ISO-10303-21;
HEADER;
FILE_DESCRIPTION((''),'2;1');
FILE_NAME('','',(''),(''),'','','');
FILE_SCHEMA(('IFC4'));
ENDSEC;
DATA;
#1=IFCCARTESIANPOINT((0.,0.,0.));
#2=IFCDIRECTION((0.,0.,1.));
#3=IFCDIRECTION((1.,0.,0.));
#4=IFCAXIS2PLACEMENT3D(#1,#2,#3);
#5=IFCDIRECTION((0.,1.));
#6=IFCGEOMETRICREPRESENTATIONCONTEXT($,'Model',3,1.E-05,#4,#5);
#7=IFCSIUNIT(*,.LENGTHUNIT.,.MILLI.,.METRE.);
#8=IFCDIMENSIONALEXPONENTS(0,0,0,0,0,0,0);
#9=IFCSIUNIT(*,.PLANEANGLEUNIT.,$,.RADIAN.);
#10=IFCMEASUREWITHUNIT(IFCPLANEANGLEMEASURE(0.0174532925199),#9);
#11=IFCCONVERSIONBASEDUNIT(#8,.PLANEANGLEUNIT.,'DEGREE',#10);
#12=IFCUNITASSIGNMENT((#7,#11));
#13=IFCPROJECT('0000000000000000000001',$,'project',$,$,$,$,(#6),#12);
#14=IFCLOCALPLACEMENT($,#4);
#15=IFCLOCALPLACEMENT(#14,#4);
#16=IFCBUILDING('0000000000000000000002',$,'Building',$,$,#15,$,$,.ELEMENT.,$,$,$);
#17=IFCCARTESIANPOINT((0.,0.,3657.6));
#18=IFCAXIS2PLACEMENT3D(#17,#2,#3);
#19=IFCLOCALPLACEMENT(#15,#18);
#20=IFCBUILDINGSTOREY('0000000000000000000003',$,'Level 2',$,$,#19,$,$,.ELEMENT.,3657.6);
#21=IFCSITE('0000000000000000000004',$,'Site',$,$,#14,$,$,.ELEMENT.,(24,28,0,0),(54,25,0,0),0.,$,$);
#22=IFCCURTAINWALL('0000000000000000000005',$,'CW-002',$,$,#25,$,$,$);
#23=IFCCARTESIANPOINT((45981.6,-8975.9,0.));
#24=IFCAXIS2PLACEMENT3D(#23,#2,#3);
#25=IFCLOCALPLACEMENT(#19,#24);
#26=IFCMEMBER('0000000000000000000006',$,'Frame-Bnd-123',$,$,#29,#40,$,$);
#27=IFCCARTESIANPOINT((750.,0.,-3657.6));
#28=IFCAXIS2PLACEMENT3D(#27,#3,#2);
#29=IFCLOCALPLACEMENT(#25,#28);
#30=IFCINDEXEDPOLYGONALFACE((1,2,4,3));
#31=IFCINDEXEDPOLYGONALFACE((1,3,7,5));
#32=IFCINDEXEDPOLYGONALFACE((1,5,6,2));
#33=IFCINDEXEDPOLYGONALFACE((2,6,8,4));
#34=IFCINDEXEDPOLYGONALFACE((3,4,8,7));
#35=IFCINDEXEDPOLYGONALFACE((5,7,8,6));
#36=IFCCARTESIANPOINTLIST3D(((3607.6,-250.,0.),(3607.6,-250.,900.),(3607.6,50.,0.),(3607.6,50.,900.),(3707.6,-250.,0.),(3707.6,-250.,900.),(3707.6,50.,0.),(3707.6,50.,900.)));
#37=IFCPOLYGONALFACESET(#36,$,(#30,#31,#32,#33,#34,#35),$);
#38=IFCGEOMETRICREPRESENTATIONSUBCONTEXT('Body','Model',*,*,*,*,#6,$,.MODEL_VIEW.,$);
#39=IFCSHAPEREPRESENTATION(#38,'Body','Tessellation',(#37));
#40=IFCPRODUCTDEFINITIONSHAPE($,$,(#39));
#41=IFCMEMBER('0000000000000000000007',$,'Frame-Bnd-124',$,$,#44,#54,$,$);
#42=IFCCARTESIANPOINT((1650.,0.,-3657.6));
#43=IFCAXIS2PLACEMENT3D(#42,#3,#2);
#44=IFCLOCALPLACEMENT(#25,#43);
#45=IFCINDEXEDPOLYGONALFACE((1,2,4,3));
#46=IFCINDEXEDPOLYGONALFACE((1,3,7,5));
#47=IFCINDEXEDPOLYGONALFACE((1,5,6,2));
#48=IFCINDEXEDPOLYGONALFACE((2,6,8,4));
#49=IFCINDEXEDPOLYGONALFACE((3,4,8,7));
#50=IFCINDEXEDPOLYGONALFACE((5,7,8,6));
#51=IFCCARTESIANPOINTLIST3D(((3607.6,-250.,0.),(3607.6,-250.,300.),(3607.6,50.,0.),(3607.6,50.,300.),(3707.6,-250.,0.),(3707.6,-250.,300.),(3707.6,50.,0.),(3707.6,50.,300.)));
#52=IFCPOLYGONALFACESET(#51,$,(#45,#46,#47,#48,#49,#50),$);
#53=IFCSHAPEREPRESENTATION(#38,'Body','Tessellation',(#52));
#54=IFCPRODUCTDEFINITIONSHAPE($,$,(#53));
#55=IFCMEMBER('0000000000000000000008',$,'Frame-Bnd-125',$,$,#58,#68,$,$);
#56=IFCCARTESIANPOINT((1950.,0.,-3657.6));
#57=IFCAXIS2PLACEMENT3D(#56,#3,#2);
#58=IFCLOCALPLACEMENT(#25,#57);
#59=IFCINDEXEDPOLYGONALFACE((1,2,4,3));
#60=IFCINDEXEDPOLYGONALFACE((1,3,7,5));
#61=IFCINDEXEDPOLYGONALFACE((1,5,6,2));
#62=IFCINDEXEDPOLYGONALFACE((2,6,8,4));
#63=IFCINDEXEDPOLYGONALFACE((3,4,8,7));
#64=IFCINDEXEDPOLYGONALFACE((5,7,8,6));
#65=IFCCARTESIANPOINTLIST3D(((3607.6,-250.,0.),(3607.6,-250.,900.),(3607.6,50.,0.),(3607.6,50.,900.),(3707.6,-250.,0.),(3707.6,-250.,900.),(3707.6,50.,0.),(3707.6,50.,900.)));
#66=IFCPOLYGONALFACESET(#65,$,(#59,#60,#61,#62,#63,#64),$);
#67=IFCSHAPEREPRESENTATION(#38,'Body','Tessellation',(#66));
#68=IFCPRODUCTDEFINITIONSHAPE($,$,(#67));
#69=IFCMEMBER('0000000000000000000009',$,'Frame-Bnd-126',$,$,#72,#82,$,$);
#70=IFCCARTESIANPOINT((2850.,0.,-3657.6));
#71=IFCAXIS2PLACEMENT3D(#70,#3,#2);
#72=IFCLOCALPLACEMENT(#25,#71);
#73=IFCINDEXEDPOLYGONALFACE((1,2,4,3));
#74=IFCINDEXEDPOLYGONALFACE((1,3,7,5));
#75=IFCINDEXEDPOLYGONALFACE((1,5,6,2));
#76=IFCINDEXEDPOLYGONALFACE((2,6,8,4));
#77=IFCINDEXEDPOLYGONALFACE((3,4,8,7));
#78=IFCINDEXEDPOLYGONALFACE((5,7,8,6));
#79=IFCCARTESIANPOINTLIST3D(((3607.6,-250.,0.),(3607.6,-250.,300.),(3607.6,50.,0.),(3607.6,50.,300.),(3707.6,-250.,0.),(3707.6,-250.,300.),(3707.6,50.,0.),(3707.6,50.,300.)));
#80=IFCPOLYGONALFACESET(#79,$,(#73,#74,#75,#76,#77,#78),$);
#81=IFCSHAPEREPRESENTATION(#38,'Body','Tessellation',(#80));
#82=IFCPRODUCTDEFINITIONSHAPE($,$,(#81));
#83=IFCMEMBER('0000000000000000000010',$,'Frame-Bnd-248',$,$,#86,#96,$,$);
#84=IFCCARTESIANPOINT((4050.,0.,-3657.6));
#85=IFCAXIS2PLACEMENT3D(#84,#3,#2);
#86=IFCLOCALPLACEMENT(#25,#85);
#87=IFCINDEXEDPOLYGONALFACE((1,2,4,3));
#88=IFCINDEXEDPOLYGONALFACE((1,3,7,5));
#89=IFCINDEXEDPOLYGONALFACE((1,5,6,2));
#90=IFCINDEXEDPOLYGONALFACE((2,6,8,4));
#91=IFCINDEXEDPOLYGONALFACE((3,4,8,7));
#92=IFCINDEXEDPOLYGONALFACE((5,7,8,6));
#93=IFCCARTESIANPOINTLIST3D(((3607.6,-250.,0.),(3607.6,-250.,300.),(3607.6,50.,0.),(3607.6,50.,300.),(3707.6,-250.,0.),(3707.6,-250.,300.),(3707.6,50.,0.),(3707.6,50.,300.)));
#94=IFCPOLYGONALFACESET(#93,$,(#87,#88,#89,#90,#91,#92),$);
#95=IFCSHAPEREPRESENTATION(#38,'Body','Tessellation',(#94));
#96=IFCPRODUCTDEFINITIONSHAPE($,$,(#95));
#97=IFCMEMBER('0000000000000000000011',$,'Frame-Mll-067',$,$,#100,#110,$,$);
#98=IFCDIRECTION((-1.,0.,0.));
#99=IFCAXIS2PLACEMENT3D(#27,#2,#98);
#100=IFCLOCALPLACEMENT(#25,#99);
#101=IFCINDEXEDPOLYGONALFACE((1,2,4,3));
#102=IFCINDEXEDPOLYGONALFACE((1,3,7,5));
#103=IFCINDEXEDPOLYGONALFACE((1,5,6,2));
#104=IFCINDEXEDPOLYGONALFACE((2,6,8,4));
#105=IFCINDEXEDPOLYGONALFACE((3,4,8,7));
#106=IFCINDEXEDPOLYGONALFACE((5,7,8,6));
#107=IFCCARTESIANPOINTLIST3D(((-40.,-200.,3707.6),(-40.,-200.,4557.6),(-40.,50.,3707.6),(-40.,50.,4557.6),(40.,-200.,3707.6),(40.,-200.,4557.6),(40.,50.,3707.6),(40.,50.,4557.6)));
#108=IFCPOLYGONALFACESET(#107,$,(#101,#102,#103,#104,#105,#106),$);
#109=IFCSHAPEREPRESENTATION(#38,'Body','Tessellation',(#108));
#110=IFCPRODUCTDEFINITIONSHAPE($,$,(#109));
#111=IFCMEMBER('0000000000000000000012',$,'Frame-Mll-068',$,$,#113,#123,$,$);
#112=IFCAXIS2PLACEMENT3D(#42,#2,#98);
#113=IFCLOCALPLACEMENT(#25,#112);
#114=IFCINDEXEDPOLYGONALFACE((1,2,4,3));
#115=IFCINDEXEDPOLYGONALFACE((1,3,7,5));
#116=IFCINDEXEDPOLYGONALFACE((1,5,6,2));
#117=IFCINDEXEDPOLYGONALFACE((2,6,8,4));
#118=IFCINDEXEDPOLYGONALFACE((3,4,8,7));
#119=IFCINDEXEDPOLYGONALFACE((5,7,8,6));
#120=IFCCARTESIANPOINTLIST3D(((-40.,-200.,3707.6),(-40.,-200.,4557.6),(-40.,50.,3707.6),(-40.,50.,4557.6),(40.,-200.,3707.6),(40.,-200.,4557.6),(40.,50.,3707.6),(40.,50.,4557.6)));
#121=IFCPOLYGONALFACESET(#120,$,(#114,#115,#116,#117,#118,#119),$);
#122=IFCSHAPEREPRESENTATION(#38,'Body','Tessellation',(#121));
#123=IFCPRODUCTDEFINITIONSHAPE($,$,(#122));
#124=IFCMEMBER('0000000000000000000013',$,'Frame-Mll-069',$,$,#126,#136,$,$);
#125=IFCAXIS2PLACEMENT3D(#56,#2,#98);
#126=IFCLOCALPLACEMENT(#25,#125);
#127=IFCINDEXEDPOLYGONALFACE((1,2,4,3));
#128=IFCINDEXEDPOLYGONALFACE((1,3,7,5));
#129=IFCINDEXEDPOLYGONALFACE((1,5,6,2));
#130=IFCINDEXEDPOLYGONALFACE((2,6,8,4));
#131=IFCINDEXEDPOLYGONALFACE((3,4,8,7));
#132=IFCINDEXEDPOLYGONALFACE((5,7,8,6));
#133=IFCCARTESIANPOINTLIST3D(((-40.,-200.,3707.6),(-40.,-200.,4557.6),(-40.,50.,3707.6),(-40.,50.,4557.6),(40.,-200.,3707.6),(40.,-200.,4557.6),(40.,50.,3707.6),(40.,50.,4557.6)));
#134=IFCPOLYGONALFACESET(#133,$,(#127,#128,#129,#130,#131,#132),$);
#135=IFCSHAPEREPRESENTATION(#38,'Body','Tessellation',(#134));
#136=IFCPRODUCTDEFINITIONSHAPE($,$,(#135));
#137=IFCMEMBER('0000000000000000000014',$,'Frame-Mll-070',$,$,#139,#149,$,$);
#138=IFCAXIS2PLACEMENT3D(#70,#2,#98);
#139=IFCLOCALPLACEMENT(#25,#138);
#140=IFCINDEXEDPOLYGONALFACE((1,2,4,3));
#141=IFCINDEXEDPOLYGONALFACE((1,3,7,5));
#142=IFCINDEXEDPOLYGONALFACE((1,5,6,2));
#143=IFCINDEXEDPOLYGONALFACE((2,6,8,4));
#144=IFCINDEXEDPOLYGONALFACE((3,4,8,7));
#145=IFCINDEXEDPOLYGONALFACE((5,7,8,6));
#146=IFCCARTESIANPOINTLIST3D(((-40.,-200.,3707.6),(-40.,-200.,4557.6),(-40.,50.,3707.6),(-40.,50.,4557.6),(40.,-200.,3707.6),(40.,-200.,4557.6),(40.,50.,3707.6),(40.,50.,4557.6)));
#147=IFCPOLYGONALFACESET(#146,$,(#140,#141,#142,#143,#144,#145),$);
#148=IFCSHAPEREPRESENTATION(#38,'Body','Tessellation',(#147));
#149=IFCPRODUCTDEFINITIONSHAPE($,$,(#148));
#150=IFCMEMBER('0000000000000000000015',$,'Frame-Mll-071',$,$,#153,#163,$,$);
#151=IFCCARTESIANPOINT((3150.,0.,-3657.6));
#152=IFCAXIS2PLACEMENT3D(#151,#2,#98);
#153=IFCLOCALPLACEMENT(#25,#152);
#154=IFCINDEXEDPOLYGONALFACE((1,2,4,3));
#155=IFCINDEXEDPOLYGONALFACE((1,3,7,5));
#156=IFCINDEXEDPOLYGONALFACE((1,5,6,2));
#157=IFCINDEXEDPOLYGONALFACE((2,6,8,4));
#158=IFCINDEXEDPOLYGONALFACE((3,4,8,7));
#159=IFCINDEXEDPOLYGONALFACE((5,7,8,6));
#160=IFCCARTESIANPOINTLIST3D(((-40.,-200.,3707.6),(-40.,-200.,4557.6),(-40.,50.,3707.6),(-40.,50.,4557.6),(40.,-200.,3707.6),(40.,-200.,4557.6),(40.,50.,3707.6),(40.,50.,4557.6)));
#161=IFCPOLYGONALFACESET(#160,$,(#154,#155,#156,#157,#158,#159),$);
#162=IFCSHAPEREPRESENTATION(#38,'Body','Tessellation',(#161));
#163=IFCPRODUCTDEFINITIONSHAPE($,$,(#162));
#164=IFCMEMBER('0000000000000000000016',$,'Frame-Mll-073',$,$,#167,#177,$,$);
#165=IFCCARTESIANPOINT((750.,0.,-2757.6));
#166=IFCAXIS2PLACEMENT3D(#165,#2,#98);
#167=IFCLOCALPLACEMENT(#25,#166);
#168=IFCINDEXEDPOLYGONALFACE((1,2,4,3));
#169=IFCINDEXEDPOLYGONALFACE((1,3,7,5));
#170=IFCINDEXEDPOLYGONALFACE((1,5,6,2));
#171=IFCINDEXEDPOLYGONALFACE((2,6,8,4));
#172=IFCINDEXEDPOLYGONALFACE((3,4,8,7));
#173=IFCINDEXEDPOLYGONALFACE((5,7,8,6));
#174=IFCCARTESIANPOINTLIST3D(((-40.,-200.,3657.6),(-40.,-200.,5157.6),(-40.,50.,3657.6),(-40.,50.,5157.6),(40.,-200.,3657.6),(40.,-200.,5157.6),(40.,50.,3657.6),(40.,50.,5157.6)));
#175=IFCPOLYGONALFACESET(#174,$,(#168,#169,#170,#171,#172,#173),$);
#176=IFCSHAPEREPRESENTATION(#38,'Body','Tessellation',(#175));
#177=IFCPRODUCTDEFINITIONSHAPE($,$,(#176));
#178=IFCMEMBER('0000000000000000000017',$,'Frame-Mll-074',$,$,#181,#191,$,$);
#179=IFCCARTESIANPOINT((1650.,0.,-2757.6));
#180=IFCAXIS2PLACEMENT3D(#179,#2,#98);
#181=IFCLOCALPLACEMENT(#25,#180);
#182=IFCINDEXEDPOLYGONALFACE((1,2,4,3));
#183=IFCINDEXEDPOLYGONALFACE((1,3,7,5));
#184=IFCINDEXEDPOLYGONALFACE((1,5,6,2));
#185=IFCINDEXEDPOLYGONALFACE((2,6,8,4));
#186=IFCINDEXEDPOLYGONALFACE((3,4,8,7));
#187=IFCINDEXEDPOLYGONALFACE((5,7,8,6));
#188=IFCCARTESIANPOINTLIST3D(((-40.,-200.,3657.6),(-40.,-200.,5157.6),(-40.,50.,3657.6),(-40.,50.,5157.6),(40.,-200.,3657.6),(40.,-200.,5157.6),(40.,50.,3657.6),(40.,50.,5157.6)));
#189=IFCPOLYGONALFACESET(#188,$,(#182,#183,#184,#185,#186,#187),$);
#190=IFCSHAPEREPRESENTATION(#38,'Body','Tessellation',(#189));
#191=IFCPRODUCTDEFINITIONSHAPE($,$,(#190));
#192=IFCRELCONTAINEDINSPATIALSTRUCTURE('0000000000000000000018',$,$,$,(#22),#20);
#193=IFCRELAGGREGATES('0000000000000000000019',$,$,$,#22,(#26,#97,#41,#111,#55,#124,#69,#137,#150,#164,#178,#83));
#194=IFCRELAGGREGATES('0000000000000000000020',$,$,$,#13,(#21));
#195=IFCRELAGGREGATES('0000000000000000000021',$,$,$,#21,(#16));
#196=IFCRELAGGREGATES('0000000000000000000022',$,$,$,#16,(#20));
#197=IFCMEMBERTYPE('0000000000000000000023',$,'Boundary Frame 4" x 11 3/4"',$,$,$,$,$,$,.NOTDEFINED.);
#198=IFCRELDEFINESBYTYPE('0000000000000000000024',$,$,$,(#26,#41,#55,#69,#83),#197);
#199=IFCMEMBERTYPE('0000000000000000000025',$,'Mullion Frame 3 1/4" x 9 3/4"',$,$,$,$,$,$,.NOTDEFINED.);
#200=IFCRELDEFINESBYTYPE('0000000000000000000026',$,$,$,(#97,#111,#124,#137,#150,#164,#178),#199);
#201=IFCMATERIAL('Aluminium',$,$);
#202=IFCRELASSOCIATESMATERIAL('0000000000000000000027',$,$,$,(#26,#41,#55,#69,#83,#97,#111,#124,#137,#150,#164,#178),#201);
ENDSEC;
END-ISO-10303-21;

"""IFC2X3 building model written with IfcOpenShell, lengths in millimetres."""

from ifc_helpers import new_model, entity, si_unit, converted_unit, direction, frame, origin_with_axes, place, context, subcontext, project, spatial, polyline, outline, extrude, material, type_object, element, aggregate, save


model = new_model("IFC2X3")

# Units and contexts
model_context = context("Model", 3, precision=1e-05, world=origin_with_axes(), true_north=direction((0.0, 1.0)))
body_context = subcontext(model_context, "Body", "Model", "MODEL_VIEW")
ifc_project = project(units=[si_unit("LENGTHUNIT", "METRE", prefix="MILLI"), converted_unit("PLANEANGLEUNIT", "DEGREE", entity("IfcPlaneAngleMeasure", 0.0174532925199), si_unit("PLANEANGLEUNIT", "RADIAN"), dimensions=[0, 0, 0, 0, 0, 0, 0])], contexts=[model_context])

# Site, building, storey
site_placement = place(None, origin_with_axes())
site = spatial("IfcSite", under=ifc_project, at=site_placement, Name="Site", CompositionType="ELEMENT", RefLatitude=(24, 28, 0, 0), RefLongitude=(54, 25, 0, 0), RefElevation=0.0)
building_placement = place(site_placement, origin_with_axes())
building = spatial("IfcBuilding", under=site, at=building_placement, Name="Building", CompositionType="ELEMENT")
storey_placement = place(building_placement, frame((0.0, 0.0, 3657.6), z_axis=(0.0, 0.0, 1.0), x_axis=(1.0, 0.0, 0.0)))
storey = spatial("IfcBuildingStorey", under=building, at=storey_placement, Name="Level 2", CompositionType="ELEMENT", Elevation=3657.6)

# Curtain wall, members
curtain_wall_placement = place(storey_placement, frame((45981.6, -8975.9, 0.0), z_axis=(0.0, 0.0, 1.0), x_axis=(1.0, 0.0, 0.0)))
curtain_wall = element("IfcCurtainWall", 1, at=curtain_wall_placement, inside=storey, Name="CW-002")
ifc_material_1 = material(Name="Aluminium")
member_type_1 = type_object("IfcMemberType", Name="Boundary Frame 4\" x 11 3/4\"", PredefinedType="NOTDEFINED")
member_1_placement = place(curtain_wall_placement, frame((750.0, 0.0, -3657.6), z_axis=(1.0, 0.0, 0.0), x_axis=(0.0, 0.0, 1.0)))
member_1 = element("IfcMember", 2, at=member_1_placement, type_object=member_type_1, material=ifc_material_1, Name="Frame-Bnd-123", context=body_context, shape_type="SweptSolid", body=[
    extrude(outline(polyline([(-250.0, -3707.6), (50.0, -3707.6), (50.0, -3607.6), (-250.0, -3607.6), (-250.0, -3707.6)])), frame((0.0, 0.0, 0.0), z_axis=(0.0, 0.0, 1.0), x_axis=(0.0, 1.0, 0.0)), (0.0, 0.0, 1.0), 900.0),
])
member_2_placement = place(curtain_wall_placement, frame((1650.0, 0.0, -3657.6), z_axis=(1.0, 0.0, 0.0), x_axis=(0.0, 0.0, 1.0)))
member_2 = element("IfcMember", 3, at=member_2_placement, type_object=member_type_1, material=ifc_material_1, Name="Frame-Bnd-124", context=body_context, shape_type="SweptSolid", body=[
    extrude(outline(polyline([(-250.0, -3707.6), (50.0, -3707.6), (50.0, -3607.6), (-250.0, -3607.6), (-250.0, -3707.6)])), frame((0.0, 0.0, 0.0), z_axis=(0.0, 0.0, 1.0), x_axis=(0.0, 1.0, 0.0)), (0.0, 0.0, 1.0), 300.0),
])
member_3_placement = place(curtain_wall_placement, frame((1950.0, 0.0, -3657.6), z_axis=(1.0, 0.0, 0.0), x_axis=(0.0, 0.0, 1.0)))
member_3 = element("IfcMember", 4, at=member_3_placement, type_object=member_type_1, material=ifc_material_1, Name="Frame-Bnd-125", context=body_context, shape_type="SweptSolid", body=[
    extrude(outline(polyline([(-250.0, -3707.6), (50.0, -3707.6), (50.0, -3607.6), (-250.0, -3607.6), (-250.0, -3707.6)])), frame((0.0, 0.0, 0.0), z_axis=(0.0, 0.0, 1.0), x_axis=(0.0, 1.0, 0.0)), (0.0, 0.0, 1.0), 900.0),
])
member_4_placement = place(curtain_wall_placement, frame((2850.0, 0.0, -3657.6), z_axis=(1.0, 0.0, 0.0), x_axis=(0.0, 0.0, 1.0)))
member_4 = element("IfcMember", 5, at=member_4_placement, type_object=member_type_1, material=ifc_material_1, Name="Frame-Bnd-126", context=body_context, shape_type="SweptSolid", body=[
    extrude(outline(polyline([(-250.0, -3707.6), (50.0, -3707.6), (50.0, -3607.6), (-250.0, -3607.6), (-250.0, -3707.6)])), frame((0.0, 0.0, 0.0), z_axis=(0.0, 0.0, 1.0), x_axis=(0.0, 1.0, 0.0)), (0.0, 0.0, 1.0), 300.0),
])
member_5_placement = place(curtain_wall_placement, frame((4050.0, 0.0, -3657.6), z_axis=(1.0, 0.0, 0.0), x_axis=(0.0, 0.0, 1.0)))
member_5 = element("IfcMember", 6, at=member_5_placement, type_object=member_type_1, material=ifc_material_1, Name="Frame-Bnd-248", context=body_context, shape_type="SweptSolid", body=[
    extrude(outline(polyline([(-250.0, -3707.6), (50.0, -3707.6), (50.0, -3607.6), (-250.0, -3607.6), (-250.0, -3707.6)])), frame((0.0, 0.0, 0.0), z_axis=(0.0, 0.0, 1.0), x_axis=(0.0, 1.0, 0.0)), (0.0, 0.0, 1.0), 300.0),
])
member_type_2 = type_object("IfcMemberType", Name="Mullion Frame 3 1/4\" x 9 3/4\"", PredefinedType="NOTDEFINED")
member_6_placement = place(curtain_wall_placement, frame((750.0, 0.0, -3657.6), z_axis=(0.0, 0.0, 1.0), x_axis=(-1.0, 0.0, 0.0)))
member_6 = element("IfcMember", 7, at=member_6_placement, type_object=member_type_2, material=ifc_material_1, Name="Frame-Mll-067", context=body_context, shape_type="SweptSolid", body=[
    extrude(outline(polyline([(-40.0, 200.0), (-40.0, -50.0), (40.0, -50.0), (40.0, 200.0), (-40.0, 200.0)])), frame((0.0, 0.0, 3707.6), z_axis=(0.0, 0.0, 1.0), x_axis=(-1.0, 0.0, 0.0)), (0.0, 0.0, 1.0), 850.0),
])
member_7_placement = place(curtain_wall_placement, frame((1650.0, 0.0, -3657.6), z_axis=(0.0, 0.0, 1.0), x_axis=(-1.0, 0.0, 0.0)))
member_7 = element("IfcMember", 8, at=member_7_placement, type_object=member_type_2, material=ifc_material_1, Name="Frame-Mll-068", context=body_context, shape_type="SweptSolid", body=[
    extrude(outline(polyline([(-40.0, 200.0), (-40.0, -50.0), (40.0, -50.0), (40.0, 200.0), (-40.0, 200.0)])), frame((0.0, 0.0, 3707.6), z_axis=(0.0, 0.0, 1.0), x_axis=(-1.0, 0.0, 0.0)), (0.0, 0.0, 1.0), 850.0),
])
member_8_placement = place(curtain_wall_placement, frame((1950.0, 0.0, -3657.6), z_axis=(0.0, 0.0, 1.0), x_axis=(-1.0, 0.0, 0.0)))
member_8 = element("IfcMember", 9, at=member_8_placement, type_object=member_type_2, material=ifc_material_1, Name="Frame-Mll-069", context=body_context, shape_type="SweptSolid", body=[
    extrude(outline(polyline([(-40.0, 200.0), (-40.0, -50.0), (40.0, -50.0), (40.0, 200.0), (-40.0, 200.0)])), frame((0.0, 0.0, 3707.6), z_axis=(0.0, 0.0, 1.0), x_axis=(-1.0, 0.0, 0.0)), (0.0, 0.0, 1.0), 850.0),
])
member_9_placement = place(curtain_wall_placement, frame((2850.0, 0.0, -3657.6), z_axis=(0.0, 0.0, 1.0), x_axis=(-1.0, 0.0, 0.0)))
member_9 = element("IfcMember", 10, at=member_9_placement, type_object=member_type_2, material=ifc_material_1, Name="Frame-Mll-070", context=body_context, shape_type="SweptSolid", body=[
    extrude(outline(polyline([(-40.0, 200.0), (-40.0, -50.0), (40.0, -50.0), (40.0, 200.0), (-40.0, 200.0)])), frame((0.0, 0.0, 3707.6), z_axis=(0.0, 0.0, 1.0), x_axis=(-1.0, 0.0, 0.0)), (0.0, 0.0, 1.0), 850.0),
])
member_10_placement = place(curtain_wall_placement, frame((3150.0, 0.0, -3657.6), z_axis=(0.0, 0.0, 1.0), x_axis=(-1.0, 0.0, 0.0)))
member_10 = element("IfcMember", 11, at=member_10_placement, type_object=member_type_2, material=ifc_material_1, Name="Frame-Mll-071", context=body_context, shape_type="SweptSolid", body=[
    extrude(outline(polyline([(-40.0, 200.0), (-40.0, -50.0), (40.0, -50.0), (40.0, 200.0), (-40.0, 200.0)])), frame((0.0, 0.0, 3707.6), z_axis=(0.0, 0.0, 1.0), x_axis=(-1.0, 0.0, 0.0)), (0.0, 0.0, 1.0), 850.0),
])
member_11_placement = place(curtain_wall_placement, frame((750.0, 0.0, -2757.6), z_axis=(0.0, 0.0, 1.0), x_axis=(-1.0, 0.0, 0.0)))
member_11 = element("IfcMember", 12, at=member_11_placement, type_object=member_type_2, material=ifc_material_1, Name="Frame-Mll-073", context=body_context, shape_type="SweptSolid", body=[
    extrude(outline(polyline([(-40.0, 200.0), (-40.0, -50.0), (40.0, -50.0), (40.0, 200.0), (-40.0, 200.0)])), frame((0.0, 0.0, 3657.6), z_axis=(0.0, 0.0, 1.0), x_axis=(-1.0, 0.0, 0.0)), (0.0, 0.0, 1.0), 1500.0),
])
member_12_placement = place(curtain_wall_placement, frame((1650.0, 0.0, -2757.6), z_axis=(0.0, 0.0, 1.0), x_axis=(-1.0, 0.0, 0.0)))
member_12 = element("IfcMember", 13, at=member_12_placement, type_object=member_type_2, material=ifc_material_1, Name="Frame-Mll-074", context=body_context, shape_type="SweptSolid", body=[
    extrude(outline(polyline([(-40.0, 200.0), (-40.0, -50.0), (40.0, -50.0), (40.0, 200.0), (-40.0, 200.0)])), frame((0.0, 0.0, 3657.6), z_axis=(0.0, 0.0, 1.0), x_axis=(-1.0, 0.0, 0.0)), (0.0, 0.0, 1.0), 1500.0),
])
aggregate(curtain_wall, [member_1, member_6, member_2, member_7, member_3, member_8, member_4, member_9, member_10, member_11, member_12, member_5])

save(model, "model.ifc")
